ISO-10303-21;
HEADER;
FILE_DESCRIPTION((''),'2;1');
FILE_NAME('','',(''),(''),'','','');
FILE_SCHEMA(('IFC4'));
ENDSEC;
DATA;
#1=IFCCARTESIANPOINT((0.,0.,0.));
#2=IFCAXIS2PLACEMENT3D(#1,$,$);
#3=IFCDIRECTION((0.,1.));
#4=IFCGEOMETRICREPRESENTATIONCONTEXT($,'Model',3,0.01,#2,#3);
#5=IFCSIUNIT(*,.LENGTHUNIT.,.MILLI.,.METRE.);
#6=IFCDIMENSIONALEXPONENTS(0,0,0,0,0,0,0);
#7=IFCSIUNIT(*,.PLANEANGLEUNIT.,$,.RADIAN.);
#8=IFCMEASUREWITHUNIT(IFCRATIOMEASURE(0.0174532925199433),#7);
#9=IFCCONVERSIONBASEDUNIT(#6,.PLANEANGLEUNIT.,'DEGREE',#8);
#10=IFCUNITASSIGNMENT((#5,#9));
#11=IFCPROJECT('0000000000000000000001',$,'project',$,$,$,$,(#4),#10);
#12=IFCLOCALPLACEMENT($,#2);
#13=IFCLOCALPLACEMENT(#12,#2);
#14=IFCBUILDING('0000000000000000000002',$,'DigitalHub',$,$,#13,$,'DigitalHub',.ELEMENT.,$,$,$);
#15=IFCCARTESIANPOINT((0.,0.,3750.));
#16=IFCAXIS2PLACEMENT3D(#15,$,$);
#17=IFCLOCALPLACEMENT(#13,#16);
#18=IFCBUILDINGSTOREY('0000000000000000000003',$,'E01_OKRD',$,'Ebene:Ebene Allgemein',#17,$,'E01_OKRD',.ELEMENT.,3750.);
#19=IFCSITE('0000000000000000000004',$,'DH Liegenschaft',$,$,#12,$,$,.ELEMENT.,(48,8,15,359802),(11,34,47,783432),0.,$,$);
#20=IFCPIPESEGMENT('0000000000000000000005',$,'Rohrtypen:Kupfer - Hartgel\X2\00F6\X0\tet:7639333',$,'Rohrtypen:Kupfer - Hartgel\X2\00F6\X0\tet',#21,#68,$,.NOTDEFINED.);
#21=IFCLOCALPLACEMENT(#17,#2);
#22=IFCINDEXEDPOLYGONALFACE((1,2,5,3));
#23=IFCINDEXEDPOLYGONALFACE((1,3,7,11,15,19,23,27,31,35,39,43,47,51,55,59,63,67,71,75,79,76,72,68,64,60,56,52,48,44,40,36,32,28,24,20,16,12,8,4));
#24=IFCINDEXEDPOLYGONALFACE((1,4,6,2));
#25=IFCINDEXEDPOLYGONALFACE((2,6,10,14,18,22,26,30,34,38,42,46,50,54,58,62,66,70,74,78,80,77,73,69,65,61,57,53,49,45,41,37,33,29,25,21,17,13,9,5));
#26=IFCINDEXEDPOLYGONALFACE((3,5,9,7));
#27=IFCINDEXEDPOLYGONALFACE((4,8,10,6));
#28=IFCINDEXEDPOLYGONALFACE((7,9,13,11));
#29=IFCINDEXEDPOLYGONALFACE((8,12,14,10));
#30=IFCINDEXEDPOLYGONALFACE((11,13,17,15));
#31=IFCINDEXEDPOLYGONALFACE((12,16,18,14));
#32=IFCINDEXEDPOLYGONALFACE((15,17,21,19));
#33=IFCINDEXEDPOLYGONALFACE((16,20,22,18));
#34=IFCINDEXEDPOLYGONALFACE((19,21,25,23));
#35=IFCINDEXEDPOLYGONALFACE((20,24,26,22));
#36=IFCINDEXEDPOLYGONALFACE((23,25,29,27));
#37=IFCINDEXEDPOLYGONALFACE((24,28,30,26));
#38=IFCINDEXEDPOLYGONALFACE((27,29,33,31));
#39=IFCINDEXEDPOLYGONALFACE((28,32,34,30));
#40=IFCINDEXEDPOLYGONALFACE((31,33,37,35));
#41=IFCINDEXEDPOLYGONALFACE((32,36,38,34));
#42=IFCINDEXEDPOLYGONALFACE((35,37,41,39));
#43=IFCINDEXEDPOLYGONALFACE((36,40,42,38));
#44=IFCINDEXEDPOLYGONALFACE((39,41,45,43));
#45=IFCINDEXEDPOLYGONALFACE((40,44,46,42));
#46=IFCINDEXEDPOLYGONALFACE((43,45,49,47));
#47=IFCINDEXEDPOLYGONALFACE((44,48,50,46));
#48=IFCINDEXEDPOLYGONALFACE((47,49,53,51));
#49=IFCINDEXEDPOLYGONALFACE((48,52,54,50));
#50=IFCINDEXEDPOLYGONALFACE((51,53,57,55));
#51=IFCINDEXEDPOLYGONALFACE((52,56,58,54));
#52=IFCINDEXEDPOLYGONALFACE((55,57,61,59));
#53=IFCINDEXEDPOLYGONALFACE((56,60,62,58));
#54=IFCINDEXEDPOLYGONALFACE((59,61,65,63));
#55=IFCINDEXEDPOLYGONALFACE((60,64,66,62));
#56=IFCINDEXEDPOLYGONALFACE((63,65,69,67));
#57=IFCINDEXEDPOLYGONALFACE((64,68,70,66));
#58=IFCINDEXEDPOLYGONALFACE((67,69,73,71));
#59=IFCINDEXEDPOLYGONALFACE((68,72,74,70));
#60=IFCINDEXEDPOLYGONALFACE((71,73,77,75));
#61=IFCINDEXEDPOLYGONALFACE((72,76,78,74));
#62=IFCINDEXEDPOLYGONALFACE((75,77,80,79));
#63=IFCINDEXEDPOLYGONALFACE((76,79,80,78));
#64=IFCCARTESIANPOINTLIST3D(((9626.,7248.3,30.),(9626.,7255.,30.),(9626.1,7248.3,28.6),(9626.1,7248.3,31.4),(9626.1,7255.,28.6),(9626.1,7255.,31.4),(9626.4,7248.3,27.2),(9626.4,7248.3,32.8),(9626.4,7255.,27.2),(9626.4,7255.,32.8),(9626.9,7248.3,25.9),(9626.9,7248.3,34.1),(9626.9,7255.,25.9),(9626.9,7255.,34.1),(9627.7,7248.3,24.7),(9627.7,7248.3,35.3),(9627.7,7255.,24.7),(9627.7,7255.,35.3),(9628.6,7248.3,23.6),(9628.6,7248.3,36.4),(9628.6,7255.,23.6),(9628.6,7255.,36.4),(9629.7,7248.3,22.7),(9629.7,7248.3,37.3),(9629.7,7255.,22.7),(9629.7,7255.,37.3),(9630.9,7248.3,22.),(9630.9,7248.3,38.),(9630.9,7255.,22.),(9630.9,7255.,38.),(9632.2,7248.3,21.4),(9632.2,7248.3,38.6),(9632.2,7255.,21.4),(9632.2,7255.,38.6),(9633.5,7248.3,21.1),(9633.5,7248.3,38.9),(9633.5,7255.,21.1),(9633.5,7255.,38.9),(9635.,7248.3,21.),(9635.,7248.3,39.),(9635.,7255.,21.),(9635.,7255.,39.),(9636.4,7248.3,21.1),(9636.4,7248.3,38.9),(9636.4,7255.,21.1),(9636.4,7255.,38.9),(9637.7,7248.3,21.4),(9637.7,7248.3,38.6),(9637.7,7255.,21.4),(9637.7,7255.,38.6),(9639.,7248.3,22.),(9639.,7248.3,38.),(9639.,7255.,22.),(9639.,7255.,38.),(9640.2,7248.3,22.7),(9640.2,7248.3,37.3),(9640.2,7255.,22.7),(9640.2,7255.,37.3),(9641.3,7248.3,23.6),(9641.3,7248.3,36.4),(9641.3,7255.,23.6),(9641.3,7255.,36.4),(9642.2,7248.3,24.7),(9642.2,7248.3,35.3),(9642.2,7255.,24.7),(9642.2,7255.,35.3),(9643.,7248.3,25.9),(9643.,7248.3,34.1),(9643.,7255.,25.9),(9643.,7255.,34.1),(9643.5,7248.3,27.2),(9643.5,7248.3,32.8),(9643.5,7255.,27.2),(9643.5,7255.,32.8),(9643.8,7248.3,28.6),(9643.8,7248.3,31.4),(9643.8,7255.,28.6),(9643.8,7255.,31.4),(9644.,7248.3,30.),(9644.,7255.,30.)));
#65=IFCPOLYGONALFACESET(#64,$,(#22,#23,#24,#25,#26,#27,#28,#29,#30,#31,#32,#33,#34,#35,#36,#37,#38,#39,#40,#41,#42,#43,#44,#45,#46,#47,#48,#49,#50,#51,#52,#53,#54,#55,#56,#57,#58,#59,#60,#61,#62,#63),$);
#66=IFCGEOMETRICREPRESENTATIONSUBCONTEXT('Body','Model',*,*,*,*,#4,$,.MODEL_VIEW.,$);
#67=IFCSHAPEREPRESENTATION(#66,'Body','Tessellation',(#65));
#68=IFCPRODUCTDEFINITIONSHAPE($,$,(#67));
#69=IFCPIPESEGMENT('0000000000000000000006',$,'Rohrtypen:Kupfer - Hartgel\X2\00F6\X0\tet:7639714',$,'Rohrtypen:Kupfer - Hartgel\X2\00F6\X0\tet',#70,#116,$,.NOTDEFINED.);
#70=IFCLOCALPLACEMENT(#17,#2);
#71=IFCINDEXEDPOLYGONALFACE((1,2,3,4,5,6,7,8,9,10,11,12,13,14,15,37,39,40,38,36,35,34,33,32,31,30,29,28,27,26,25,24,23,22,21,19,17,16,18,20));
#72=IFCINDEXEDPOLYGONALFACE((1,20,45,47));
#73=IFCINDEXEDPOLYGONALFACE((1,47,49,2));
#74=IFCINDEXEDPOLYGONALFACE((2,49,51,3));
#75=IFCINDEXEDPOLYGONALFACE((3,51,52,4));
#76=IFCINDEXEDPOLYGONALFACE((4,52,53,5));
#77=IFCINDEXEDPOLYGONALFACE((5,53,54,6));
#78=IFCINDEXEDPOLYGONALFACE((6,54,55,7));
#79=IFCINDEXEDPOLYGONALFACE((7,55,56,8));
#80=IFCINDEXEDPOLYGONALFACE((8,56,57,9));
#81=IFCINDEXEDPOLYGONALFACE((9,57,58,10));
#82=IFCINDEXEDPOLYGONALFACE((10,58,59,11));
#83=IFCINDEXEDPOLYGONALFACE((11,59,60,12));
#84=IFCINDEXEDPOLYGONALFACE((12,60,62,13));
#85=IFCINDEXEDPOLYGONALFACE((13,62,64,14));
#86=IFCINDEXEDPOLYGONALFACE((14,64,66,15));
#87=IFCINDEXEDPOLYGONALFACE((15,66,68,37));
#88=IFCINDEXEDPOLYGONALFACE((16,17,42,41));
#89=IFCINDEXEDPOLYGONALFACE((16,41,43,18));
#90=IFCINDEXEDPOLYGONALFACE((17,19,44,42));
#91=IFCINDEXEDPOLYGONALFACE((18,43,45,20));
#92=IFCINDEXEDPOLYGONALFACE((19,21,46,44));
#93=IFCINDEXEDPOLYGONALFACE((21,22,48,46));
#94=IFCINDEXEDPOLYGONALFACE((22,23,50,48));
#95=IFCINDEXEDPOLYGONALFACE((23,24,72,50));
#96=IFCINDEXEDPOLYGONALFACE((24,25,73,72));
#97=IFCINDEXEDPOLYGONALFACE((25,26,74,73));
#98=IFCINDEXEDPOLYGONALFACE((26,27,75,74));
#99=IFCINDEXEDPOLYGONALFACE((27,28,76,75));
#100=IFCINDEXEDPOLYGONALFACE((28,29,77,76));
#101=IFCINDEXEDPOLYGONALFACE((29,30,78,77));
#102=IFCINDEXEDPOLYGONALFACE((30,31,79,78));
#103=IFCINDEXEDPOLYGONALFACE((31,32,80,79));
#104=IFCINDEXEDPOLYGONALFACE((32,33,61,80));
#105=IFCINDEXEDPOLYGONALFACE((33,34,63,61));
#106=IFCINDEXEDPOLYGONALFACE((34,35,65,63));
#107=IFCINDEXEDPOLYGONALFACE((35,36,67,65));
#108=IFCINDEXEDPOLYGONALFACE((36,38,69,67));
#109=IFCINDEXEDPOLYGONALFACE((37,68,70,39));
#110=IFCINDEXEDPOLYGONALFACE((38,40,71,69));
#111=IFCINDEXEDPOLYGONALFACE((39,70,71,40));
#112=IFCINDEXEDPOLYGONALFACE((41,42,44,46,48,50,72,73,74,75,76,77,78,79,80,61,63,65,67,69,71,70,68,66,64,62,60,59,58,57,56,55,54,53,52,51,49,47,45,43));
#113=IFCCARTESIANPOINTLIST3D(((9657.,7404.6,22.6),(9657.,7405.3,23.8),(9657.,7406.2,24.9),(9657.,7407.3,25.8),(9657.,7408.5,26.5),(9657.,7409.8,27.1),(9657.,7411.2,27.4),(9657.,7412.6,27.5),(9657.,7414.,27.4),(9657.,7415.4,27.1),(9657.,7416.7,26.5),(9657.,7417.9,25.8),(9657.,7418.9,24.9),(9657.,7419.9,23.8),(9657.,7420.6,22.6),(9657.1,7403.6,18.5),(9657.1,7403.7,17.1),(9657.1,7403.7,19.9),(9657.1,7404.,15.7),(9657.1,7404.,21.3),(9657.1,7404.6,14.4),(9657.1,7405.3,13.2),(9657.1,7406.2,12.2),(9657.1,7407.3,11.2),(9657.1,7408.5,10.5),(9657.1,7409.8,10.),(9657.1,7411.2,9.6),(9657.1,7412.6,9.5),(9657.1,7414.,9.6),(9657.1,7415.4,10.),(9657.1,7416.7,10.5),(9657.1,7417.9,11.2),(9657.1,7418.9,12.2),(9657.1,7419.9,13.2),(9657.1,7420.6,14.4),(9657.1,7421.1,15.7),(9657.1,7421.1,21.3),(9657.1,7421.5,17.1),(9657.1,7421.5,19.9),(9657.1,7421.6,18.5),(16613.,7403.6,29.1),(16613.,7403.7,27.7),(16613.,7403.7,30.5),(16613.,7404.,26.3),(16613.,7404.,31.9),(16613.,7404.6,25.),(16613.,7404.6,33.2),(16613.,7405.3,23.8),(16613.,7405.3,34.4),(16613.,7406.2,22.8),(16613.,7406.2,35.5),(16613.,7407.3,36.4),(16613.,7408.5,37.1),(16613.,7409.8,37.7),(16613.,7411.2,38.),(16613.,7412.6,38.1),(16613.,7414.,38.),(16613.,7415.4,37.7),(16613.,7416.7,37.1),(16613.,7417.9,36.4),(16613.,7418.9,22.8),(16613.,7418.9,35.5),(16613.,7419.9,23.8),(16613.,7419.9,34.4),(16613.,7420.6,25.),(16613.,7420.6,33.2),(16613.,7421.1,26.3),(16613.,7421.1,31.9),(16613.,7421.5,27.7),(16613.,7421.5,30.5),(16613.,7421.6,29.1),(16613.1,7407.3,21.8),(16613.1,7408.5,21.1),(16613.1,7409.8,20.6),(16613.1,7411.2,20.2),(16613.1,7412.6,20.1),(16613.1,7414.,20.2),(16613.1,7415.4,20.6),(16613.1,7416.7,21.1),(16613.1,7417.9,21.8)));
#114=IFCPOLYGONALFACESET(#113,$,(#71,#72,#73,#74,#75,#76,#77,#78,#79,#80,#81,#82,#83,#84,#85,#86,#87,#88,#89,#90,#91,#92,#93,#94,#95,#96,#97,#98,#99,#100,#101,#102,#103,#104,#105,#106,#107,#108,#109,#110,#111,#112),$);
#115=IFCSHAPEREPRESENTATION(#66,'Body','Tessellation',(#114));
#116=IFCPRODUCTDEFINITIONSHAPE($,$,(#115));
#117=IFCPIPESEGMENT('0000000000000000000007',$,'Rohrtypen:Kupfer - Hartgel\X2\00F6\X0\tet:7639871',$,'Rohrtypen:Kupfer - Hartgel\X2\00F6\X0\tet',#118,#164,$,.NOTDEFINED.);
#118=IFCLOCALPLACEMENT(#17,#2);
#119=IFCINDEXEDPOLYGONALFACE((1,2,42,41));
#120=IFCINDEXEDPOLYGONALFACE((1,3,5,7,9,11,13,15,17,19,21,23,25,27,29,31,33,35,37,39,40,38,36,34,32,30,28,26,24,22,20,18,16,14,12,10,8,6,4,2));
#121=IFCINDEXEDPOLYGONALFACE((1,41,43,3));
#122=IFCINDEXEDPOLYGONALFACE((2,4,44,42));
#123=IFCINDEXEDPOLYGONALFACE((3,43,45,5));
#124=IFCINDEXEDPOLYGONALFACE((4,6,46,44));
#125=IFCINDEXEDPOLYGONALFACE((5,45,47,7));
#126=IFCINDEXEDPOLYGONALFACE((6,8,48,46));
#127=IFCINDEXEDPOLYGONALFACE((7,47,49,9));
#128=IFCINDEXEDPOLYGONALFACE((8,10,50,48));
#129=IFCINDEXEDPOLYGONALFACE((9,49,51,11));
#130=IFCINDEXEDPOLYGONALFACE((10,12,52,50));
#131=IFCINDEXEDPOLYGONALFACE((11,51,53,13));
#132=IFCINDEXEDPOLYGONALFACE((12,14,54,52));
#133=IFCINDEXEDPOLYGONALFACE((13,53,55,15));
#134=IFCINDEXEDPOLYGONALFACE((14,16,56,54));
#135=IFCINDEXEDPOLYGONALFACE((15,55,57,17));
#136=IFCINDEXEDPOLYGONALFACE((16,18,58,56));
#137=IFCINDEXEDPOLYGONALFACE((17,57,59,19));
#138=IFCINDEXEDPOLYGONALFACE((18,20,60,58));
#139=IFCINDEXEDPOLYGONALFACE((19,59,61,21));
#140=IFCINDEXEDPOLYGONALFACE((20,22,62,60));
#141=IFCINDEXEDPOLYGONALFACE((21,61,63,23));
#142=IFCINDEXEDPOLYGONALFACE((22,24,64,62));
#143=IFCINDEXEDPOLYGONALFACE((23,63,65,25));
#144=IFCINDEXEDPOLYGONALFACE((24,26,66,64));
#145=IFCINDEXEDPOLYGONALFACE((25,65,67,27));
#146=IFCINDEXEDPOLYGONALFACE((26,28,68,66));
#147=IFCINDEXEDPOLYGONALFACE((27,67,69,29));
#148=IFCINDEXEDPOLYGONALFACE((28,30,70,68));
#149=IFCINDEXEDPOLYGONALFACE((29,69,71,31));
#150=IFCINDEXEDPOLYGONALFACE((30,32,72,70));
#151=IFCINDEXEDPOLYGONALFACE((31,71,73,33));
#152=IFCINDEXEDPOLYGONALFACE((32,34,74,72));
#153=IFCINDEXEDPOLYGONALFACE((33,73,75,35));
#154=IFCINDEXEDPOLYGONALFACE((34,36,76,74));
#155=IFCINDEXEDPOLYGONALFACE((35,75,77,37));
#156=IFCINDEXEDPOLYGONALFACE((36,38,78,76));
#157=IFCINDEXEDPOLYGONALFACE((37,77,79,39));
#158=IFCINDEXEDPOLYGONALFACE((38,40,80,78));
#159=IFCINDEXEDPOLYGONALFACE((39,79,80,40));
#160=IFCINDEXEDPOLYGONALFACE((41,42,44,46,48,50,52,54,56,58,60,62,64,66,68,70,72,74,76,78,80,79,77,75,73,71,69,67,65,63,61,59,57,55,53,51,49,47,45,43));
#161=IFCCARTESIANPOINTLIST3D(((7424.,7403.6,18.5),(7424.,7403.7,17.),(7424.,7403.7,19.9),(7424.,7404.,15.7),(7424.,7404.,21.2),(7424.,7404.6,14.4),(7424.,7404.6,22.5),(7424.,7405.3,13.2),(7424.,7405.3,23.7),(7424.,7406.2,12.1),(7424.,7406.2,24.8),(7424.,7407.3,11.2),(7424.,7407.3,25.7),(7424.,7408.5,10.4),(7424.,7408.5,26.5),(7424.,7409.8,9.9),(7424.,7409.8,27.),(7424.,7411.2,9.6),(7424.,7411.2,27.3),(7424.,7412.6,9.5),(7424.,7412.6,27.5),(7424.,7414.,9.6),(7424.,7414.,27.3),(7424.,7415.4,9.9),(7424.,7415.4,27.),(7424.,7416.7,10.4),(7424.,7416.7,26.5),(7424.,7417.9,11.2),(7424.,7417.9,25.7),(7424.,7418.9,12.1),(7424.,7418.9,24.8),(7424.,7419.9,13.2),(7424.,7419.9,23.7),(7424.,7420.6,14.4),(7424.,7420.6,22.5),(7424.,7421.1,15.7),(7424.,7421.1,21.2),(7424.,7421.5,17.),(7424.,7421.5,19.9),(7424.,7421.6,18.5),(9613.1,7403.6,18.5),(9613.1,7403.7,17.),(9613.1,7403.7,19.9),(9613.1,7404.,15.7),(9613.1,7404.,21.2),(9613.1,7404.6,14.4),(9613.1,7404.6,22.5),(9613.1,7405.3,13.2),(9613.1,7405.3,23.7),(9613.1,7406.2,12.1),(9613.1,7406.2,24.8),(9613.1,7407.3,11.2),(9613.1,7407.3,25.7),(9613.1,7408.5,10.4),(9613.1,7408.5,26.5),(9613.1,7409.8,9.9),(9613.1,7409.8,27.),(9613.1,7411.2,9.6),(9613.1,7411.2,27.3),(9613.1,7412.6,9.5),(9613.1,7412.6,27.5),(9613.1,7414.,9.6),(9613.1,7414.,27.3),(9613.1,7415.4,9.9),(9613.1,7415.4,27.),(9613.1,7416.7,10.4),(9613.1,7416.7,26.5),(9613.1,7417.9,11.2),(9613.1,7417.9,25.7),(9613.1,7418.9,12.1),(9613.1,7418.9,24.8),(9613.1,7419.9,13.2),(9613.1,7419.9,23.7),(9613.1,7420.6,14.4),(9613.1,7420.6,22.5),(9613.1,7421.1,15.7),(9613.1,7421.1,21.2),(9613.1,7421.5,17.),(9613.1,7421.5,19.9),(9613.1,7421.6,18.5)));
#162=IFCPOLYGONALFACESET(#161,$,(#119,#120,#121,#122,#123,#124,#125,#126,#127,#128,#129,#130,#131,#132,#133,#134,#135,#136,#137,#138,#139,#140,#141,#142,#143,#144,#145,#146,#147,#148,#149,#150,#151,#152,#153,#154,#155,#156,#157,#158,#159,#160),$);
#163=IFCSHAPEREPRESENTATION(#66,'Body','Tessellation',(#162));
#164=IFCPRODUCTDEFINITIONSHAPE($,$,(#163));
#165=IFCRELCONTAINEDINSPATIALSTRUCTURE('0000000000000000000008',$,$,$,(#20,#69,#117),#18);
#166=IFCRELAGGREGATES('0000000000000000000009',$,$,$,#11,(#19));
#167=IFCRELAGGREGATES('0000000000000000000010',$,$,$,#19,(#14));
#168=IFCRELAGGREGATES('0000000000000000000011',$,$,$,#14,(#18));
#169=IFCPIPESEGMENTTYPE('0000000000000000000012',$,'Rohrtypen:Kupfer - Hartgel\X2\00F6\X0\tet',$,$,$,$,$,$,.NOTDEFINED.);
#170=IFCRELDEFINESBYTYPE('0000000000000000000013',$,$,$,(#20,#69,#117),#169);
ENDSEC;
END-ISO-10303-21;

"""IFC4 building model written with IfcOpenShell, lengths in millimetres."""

from ifc_helpers import new_model, entity, si_unit, converted_unit, direction, frame, origin, place, context, subcontext, project, spatial, indexed_curve, outline, extrude, type_object, element, save


model = new_model("IFC4")

# Units and contexts
model_context = context("Model", 3, precision=0.01, world=origin(), true_north=direction((0.0, 1.0)))
body_context = subcontext(model_context, "Body", "Model", "MODEL_VIEW")
ifc_project = project(units=[si_unit("LENGTHUNIT", "METRE", prefix="MILLI"), converted_unit("PLANEANGLEUNIT", "DEGREE", entity("IfcRatioMeasure", 0.0174532925199433), si_unit("PLANEANGLEUNIT", "RADIAN"), dimensions=[0, 0, 0, 0, 0, 0, 0])], contexts=[model_context])

# Site, building, storey
site_placement = place(None, origin())
site = spatial("IfcSite", under=ifc_project, at=site_placement, Name="DH Liegenschaft", CompositionType="ELEMENT", RefLatitude=(48, 8, 15, 359802), RefLongitude=(11, 34, 47, 783432), RefElevation=0.0)
building_placement = place(site_placement, origin())
building = spatial("IfcBuilding", under=site, at=building_placement, Name="DigitalHub", LongName="DigitalHub", CompositionType="ELEMENT")
storey_placement = place(building_placement, frame((0.0, 0.0, 3750.0)))
storey = spatial("IfcBuildingStorey", under=building, at=storey_placement, Name="E01_OKRD", ObjectType="Ebene:Ebene Allgemein", LongName="E01_OKRD", CompositionType="ELEMENT", Elevation=3750.0)

# Pipe segments
pipe_segment_type = type_object("IfcPipeSegmentType", Name="Rohrtypen:Kupfer - Hartgelötet", PredefinedType="NOTDEFINED")
pipe_segment_1_placement = place(storey_placement, frame((9624.4, 7248.3, 19.4)))
element("IfcPipeSegment", 1, at=pipe_segment_1_placement, inside=storey, type_object=pipe_segment_type, Name="Rohrtypen:Kupfer - Hartgelötet:7639333", ObjectType="Rohrtypen:Kupfer - Hartgelötet", PredefinedType="NOTDEFINED", context=body_context, shape_type="SweptSolid", body=[
    extrude(outline(indexed_curve([(9.0, 0.0), (8.9, 1.4), (8.6, 2.8), (8.0, 4.1), (7.3, 5.3), (6.4, 6.4), (5.3, 7.3), (4.1, 8.0), (2.8, 8.6), (1.4, 8.9), (0.0, 9.0), (-1.4, 8.9), (-2.8, 8.6), (-4.1, 8.0), (-5.3, 7.3), (-6.4, 6.4), (-7.3, 5.3), (-8.0, 4.1), (-8.6, 2.8), (-8.9, 1.4), (-9.0, 0.0), (-8.9, -1.4), (-8.6, -2.8), (-8.0, -4.1), (-7.3, -5.3), (-6.4, -6.4), (-5.3, -7.3), (-4.1, -8.0), (-2.8, -8.6), (-1.4, -8.9), (0.0, -9.0), (1.4, -8.9), (2.8, -8.6), (4.1, -8.0), (5.3, -7.3), (6.4, -6.4), (7.3, -5.3), (8.0, -4.1), (8.6, -2.8), (8.9, -1.4), (9.0, 0.0)], self_intersect=False)), frame((10.6, 0.0, 10.6), z_axis=(0.000018, 1.0, 0.0), x_axis=(-1.0, 0.000018, 0.0)), (0.0, 0.0, 1.0), 6.6),
])
pipe_segment_2_placement = place(storey_placement, frame((9657.0, 7402.0, 7.9)))
element("IfcPipeSegment", 2, at=pipe_segment_2_placement, inside=storey, type_object=pipe_segment_type, Name="Rohrtypen:Kupfer - Hartgelötet:7639714", ObjectType="Rohrtypen:Kupfer - Hartgelötet", PredefinedType="NOTDEFINED", context=body_context, shape_type="SweptSolid", body=[
    extrude(outline(indexed_curve([(9.0, 0.0), (8.9, 1.4), (8.6, 2.8), (8.0, 4.1), (7.3, 5.3), (6.4, 6.4), (5.3, 7.3), (4.1, 8.0), (2.8, 8.6), (1.4, 8.9), (0.0, 9.0), (-1.4, 8.9), (-2.8, 8.6), (-4.1, 8.0), (-5.3, 7.3), (-6.4, 6.4), (-7.3, 5.3), (-8.0, 4.1), (-8.6, 2.8), (-8.9, 1.4), (-9.0, 0.0), (-8.9, -1.4), (-8.6, -2.8), (-8.0, -4.1), (-7.3, -5.3), (-6.4, -6.4), (-5.3, -7.3), (-4.1, -8.0), (-2.8, -8.6), (-1.4, -8.9), (0.0, -9.0), (1.4, -8.9), (2.8, -8.6), (4.1, -8.0), (5.3, -7.3), (6.4, -6.4), (7.3, -5.3), (8.0, -4.1), (8.6, -2.8), (8.9, -1.4), (9.0, 0.0)], self_intersect=False)), frame((0.0, 10.6, 10.6), z_axis=(0.999999, 0.0, 0.001525), x_axis=(0.0, -1.0, 0.0)), (0.0, 0.0, 1.0), 6956.0),
])
pipe_segment_3_placement = place(storey_placement, frame((7424.0, 7402.0, 7.9)))
element("IfcPipeSegment", 3, at=pipe_segment_3_placement, inside=storey, type_object=pipe_segment_type, Name="Rohrtypen:Kupfer - Hartgelötet:7639871", ObjectType="Rohrtypen:Kupfer - Hartgelötet", PredefinedType="NOTDEFINED", context=body_context, shape_type="SweptSolid", body=[
    extrude(outline(indexed_curve([(9.0, 0.0), (8.9, 1.4), (8.6, 2.8), (8.0, 4.1), (7.3, 5.3), (6.4, 6.4), (5.3, 7.3), (4.1, 8.0), (2.8, 8.6), (1.4, 8.9), (0.0, 9.0), (-1.4, 8.9), (-2.8, 8.6), (-4.1, 8.0), (-5.3, 7.3), (-6.4, 6.4), (-7.3, 5.3), (-8.0, 4.1), (-8.6, 2.8), (-8.9, 1.4), (-9.0, 0.0), (-8.9, -1.4), (-8.6, -2.8), (-8.0, -4.1), (-7.3, -5.3), (-6.4, -6.4), (-5.3, -7.3), (-4.1, -8.0), (-2.8, -8.6), (-1.4, -8.9), (0.0, -9.0), (1.4, -8.9), (2.8, -8.6), (4.1, -8.0), (5.3, -7.3), (6.4, -6.4), (7.3, -5.3), (8.0, -4.1), (8.6, -2.8), (8.9, -1.4), (9.0, 0.0)], self_intersect=False)), frame((0.0, 10.6, 10.6), z_axis=(1.0, 0.0, -0.000002), x_axis=(0.0, -1.0, 0.0)), (0.0, 0.0, 1.0), 2189.1),
])

save(model, "model.ifc")
